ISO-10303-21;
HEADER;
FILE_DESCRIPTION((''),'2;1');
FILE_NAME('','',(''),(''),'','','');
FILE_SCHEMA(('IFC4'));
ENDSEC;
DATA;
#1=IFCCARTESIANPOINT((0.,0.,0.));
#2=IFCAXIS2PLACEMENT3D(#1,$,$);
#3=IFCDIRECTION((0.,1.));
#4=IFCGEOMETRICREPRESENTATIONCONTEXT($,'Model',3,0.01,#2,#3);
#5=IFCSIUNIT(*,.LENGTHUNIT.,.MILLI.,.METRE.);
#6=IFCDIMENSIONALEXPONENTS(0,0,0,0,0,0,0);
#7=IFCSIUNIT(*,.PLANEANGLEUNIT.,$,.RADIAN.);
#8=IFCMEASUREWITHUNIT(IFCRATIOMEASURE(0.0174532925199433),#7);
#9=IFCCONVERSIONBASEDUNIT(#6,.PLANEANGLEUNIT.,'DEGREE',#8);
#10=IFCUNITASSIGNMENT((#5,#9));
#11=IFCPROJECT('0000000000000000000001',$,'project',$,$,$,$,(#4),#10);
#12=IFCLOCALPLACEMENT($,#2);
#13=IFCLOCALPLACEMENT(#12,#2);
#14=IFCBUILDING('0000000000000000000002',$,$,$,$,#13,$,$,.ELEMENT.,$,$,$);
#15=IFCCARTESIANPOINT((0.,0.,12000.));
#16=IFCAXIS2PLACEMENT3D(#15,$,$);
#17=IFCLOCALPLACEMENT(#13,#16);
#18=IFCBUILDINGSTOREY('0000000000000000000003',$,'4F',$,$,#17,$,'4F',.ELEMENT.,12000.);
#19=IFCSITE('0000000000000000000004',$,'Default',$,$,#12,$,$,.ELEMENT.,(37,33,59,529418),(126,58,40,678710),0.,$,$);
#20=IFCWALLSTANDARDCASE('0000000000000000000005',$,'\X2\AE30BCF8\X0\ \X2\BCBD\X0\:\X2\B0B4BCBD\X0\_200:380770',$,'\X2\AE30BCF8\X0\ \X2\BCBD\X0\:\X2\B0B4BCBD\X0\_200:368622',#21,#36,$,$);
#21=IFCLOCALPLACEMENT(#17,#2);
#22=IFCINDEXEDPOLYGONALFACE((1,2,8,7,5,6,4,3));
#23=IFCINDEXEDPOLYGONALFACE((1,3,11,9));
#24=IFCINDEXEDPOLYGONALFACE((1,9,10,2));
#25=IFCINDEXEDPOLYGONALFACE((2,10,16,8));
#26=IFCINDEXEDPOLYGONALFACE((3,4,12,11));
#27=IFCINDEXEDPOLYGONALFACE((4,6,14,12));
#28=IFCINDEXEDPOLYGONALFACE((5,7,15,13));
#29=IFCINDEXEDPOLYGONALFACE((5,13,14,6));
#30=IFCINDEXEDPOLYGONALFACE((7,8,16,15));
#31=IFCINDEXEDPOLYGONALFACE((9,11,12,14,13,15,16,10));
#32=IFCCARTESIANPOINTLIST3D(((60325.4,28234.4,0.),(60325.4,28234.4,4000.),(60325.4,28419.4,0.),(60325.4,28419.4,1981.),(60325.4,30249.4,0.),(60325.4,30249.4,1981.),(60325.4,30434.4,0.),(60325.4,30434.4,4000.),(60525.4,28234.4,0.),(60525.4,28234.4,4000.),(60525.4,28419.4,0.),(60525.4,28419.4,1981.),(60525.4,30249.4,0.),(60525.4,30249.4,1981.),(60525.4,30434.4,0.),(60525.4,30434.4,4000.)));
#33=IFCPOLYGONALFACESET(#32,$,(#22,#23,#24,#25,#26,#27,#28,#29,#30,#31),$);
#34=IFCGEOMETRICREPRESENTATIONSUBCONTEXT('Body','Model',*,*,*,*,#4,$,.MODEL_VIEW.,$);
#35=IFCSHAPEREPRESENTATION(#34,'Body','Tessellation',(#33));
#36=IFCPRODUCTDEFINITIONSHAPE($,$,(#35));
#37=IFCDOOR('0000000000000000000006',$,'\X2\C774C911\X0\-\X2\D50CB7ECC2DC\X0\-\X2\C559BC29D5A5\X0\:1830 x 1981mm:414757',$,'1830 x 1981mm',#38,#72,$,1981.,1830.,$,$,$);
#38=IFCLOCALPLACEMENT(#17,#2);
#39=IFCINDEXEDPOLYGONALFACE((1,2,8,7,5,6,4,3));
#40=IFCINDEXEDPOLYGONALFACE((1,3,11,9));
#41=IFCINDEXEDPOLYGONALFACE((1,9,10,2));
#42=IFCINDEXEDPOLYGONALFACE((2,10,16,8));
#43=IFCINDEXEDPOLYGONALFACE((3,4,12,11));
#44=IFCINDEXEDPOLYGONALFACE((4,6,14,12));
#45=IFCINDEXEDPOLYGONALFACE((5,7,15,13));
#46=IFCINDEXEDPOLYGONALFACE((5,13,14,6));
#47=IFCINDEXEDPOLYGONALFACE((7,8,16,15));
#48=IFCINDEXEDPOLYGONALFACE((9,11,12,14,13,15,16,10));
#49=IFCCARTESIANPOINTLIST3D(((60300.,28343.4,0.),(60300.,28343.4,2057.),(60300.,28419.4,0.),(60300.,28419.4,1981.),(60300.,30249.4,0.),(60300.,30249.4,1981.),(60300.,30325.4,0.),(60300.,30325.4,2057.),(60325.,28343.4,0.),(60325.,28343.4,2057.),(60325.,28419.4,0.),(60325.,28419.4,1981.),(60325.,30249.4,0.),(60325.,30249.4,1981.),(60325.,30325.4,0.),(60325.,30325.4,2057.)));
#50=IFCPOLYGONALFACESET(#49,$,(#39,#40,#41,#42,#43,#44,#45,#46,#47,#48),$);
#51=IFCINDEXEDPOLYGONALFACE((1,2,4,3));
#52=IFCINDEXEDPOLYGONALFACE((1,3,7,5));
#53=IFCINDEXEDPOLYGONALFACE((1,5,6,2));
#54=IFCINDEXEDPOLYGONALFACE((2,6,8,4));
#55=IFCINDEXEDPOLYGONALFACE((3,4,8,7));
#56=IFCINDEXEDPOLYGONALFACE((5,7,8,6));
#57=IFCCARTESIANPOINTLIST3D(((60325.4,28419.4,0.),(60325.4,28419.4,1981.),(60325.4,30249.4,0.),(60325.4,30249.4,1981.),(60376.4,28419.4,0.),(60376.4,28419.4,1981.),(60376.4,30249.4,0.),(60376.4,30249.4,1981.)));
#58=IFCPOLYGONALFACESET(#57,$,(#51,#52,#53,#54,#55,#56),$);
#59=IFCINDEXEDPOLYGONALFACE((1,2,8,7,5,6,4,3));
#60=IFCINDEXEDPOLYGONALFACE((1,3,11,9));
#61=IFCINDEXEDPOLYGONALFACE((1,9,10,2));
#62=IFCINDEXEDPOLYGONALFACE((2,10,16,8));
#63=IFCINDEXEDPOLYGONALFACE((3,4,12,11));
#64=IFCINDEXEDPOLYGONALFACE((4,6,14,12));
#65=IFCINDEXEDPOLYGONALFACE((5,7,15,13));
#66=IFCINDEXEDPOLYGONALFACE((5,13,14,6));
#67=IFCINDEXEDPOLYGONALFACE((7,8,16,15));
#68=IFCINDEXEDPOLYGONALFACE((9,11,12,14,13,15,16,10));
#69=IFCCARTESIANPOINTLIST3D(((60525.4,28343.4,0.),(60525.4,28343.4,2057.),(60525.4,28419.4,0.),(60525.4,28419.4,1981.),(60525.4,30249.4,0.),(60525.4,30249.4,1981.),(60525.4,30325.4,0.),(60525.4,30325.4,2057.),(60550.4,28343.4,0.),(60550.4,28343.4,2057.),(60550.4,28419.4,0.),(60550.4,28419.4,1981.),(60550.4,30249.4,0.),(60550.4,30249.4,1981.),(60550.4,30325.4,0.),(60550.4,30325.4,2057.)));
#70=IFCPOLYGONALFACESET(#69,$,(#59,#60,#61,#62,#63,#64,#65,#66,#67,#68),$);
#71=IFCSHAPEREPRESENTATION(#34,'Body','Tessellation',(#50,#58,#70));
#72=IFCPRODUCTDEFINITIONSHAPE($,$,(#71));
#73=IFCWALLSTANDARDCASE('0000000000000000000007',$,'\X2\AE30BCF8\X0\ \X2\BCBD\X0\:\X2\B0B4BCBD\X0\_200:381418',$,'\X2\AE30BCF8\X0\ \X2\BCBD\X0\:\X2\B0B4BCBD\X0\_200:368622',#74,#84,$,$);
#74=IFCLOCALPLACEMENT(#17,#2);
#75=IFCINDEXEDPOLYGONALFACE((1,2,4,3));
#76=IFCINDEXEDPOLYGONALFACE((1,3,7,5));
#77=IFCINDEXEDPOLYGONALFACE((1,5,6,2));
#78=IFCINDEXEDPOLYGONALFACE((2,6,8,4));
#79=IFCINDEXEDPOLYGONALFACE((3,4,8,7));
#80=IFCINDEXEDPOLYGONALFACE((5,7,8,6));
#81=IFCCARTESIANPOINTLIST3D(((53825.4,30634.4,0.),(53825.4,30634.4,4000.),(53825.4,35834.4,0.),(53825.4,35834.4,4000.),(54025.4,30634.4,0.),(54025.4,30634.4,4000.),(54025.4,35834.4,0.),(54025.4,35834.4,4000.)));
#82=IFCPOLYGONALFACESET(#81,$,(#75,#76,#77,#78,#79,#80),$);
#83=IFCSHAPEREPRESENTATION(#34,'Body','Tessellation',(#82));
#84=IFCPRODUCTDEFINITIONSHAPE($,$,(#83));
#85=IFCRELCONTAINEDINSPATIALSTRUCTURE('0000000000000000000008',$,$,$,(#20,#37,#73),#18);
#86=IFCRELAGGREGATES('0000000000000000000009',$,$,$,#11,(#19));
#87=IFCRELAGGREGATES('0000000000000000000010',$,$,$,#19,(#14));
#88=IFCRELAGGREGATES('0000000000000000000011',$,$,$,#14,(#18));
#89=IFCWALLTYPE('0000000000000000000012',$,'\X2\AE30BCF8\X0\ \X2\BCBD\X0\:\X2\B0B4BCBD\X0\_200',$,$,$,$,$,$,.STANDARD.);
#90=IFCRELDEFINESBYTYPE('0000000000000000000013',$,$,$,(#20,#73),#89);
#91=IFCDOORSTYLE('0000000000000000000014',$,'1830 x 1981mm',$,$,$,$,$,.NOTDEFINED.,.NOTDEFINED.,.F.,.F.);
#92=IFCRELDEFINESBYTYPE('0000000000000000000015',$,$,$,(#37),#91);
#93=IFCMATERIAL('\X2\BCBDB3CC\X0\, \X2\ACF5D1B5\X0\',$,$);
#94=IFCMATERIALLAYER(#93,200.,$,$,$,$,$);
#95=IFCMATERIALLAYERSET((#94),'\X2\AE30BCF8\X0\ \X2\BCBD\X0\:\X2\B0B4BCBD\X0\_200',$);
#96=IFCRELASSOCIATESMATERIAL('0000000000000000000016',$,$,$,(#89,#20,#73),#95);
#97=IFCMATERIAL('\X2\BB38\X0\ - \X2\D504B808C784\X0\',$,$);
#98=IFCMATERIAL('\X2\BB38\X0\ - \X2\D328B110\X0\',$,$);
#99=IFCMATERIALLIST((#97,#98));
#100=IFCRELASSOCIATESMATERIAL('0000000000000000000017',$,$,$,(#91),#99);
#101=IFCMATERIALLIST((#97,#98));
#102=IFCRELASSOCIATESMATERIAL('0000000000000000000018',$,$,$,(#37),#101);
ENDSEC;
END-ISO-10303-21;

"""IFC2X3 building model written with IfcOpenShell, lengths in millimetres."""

from ifc_helpers import new_model, entity, si_unit, converted_unit, direction, frame, frame_2d, origin, place, context, subcontext, project, spatial, polyline, rectangle, outline, extrude, source, transform, mapped, material, material_list, layer, layer_set, layer_usage, type_object, type_shapes, element, fill, save


model = new_model("IFC2X3")

# Units and contexts
model_context = context("Model", 3, precision=0.01, world=origin(), true_north=direction((0.0, 1.0)))
body_context = subcontext(model_context, "Body", "Model", "MODEL_VIEW")
ifc_project = project(units=[si_unit("LENGTHUNIT", "METRE", prefix="MILLI"), converted_unit("PLANEANGLEUNIT", "DEGREE", entity("IfcRatioMeasure", 0.0174532925199433), si_unit("PLANEANGLEUNIT", "RADIAN"), dimensions=[0, 0, 0, 0, 0, 0, 0])], contexts=[model_context])

# Site, building, storey
site_placement = place(None, origin())
site = spatial("IfcSite", under=ifc_project, at=site_placement, Name="Default", CompositionType="ELEMENT", RefLatitude=(37, 33, 59, 529418), RefLongitude=(126, 58, 40, 678710), RefElevation=0.0)
building_placement = place(site_placement, origin())
building = spatial("IfcBuilding", under=site, at=building_placement, CompositionType="ELEMENT")
storey_placement = place(building_placement, frame((0.0, 0.0, 12000.0)))
storey = spatial("IfcBuildingStorey", under=building, at=storey_placement, Name="4F", LongName="4F", CompositionType="ELEMENT", Elevation=12000.0)

# Shared definitions
ifc_material_1 = material(Name="벽돌, 공통")
ifc_layer_1 = layer(ifc_material_1, 200.0)
ifc_layer_set_1 = layer_set([ifc_layer_1], Name="기본 벽:내벽_200")
wall_type_1 = type_object("IfcWallType", Name="기본 벽:내벽_200", PredefinedType="STANDARD", material=ifc_layer_set_1)
ifc_material_2 = material(Name="문 - 프레임")
ifc_material_3 = material(Name="문 - 패널")

# Wall, opening, door
ifc_layer_usage_1 = layer_usage(ifc_layer_set_1, "AXIS2", "NEGATIVE", 100.0)
wall_1_placement = place(storey_placement, frame((60425.4, 28234.4, 0.0), z_axis=(0.0, 0.0, 1.0), x_axis=(0.0, 1.0, 0.0)))
wall_1 = element("IfcWallStandardCase", 1, at=wall_1_placement, inside=storey, type_object=wall_type_1, material=ifc_layer_usage_1, Name="기본 벽:내벽_200:380770", ObjectType="기본 벽:내벽_200:368622", context=body_context, shape_type="SweptSolid", body=[
    extrude(rectangle(XDim=2200.0, YDim=200.0, at=frame_2d((1100.0, 0.0), x_axis=(-1.0, 0.0))), origin(), (0.0, 0.0, 1.0), 4000.0),
])
opening_1_placement = place(wall_1_placement, frame((185.0, -100.0, 0.0)))
opening_1 = element("IfcOpeningElement", 2, at=opening_1_placement, cuts=wall_1, ObjectType="Opening", context=body_context, shape_type="SweptSolid", body=[
    extrude(rectangle(XDim=1981.0, YDim=1830.0, at=frame_2d((990.5, 915.0), x_axis=(1.0, 0.0))), frame((0.0, 0.0, 0.0), z_axis=(0.0, 1.0, 0.0), x_axis=(0.0, 0.0, 1.0)), (0.0, 0.0, 1.0), 200.0),
])
ifc_material_list_1 = material_list([ifc_material_2, ifc_material_3])
ifc_material_list_2 = material_list([ifc_material_2, ifc_material_3])
door_style_1 = type_object("IfcDoorStyle", Name="1830 x 1981mm", ConstructionType="NOTDEFINED", OperationType="NOTDEFINED", ParameterTakesPrecedence=False, Sizeable=False, material=ifc_material_list_2)
shared_shape_1 = source(origin(), body_context, "Body", "SweptSolid", [
    extrude(outline(polyline([(-991.0, -1047.5), (991.0, -1047.5), (991.0, 1009.5), (915.0, 1009.5), (915.0, -971.5), (-915.0, -971.5), (-915.0, 1009.5), (-991.0, 1009.5), (-991.0, -1047.5)])), frame((915.0, 200.4, 1009.5), z_axis=(0.0, 1.0, 0.0), x_axis=(1.0, 0.0, 0.0)), (0.0, 0.0, 1.0), 25.0),
    extrude(rectangle(XDim=51.0, YDim=1830.0, at=frame_2d((0.0, 0.0), x_axis=(1.0, 0.0))), frame((915.0, 174.5, 0.0), z_axis=(0.0, 0.0, 1.0), x_axis=(0.0, -1.0, 0.0)), (0.0, 0.0, 1.0), 1981.0),
    extrude(outline(polyline([(-971.5, 915.0), (1009.5, 915.0), (1009.5, 991.0), (-1047.5, 991.0), (-1047.5, -991.0), (1009.5, -991.0), (1009.5, -915.0), (-971.5, -915.0), (-971.5, 915.0)])), frame((915.0, -25.0, 1009.5), z_axis=(0.0, 1.0, 0.0), x_axis=(0.0, 0.0, -1.0)), (0.0, 0.0, 1.0), 25.0),
])
type_shapes(door_style_1, [shared_shape_1])
door_1_placement = place(opening_1_placement, frame((0.0, 0.0, 0.0)))
door_1 = element("IfcDoor", 3, at=door_1_placement, inside=storey, type_object=door_style_1, material=ifc_material_list_1, Name="이중-플러시-앙방향:1830 x 1981mm:414757", ObjectType="1830 x 1981mm", OverallHeight=1981.0, OverallWidth=1830.0, context=body_context, shape_type="MappedRepresentation", body=[
    mapped(shared_shape_1, transform((0.0, 0.0, 0.0), scale=1.0)),
])
fill(opening_1, door_1)

# Wall
ifc_layer_usage_2 = layer_usage(ifc_layer_set_1, "AXIS2", "NEGATIVE", 100.0)
wall_2_placement = place(storey_placement, frame((53925.4, 35834.4, 0.0), z_axis=(0.0, 0.0, 1.0), x_axis=(0.0, -1.0, 0.0)))
element("IfcWallStandardCase", 4, at=wall_2_placement, inside=storey, type_object=wall_type_1, material=ifc_layer_usage_2, Name="기본 벽:내벽_200:381418", ObjectType="기본 벽:내벽_200:368622", context=body_context, shape_type="SweptSolid", body=[
    extrude(rectangle(XDim=5200.0, YDim=200.0, at=frame_2d((2600.0, 0.0), x_axis=(-1.0, 0.0))), origin(), (0.0, 0.0, 1.0), 4000.0),
])

save(model, "model.ifc")
